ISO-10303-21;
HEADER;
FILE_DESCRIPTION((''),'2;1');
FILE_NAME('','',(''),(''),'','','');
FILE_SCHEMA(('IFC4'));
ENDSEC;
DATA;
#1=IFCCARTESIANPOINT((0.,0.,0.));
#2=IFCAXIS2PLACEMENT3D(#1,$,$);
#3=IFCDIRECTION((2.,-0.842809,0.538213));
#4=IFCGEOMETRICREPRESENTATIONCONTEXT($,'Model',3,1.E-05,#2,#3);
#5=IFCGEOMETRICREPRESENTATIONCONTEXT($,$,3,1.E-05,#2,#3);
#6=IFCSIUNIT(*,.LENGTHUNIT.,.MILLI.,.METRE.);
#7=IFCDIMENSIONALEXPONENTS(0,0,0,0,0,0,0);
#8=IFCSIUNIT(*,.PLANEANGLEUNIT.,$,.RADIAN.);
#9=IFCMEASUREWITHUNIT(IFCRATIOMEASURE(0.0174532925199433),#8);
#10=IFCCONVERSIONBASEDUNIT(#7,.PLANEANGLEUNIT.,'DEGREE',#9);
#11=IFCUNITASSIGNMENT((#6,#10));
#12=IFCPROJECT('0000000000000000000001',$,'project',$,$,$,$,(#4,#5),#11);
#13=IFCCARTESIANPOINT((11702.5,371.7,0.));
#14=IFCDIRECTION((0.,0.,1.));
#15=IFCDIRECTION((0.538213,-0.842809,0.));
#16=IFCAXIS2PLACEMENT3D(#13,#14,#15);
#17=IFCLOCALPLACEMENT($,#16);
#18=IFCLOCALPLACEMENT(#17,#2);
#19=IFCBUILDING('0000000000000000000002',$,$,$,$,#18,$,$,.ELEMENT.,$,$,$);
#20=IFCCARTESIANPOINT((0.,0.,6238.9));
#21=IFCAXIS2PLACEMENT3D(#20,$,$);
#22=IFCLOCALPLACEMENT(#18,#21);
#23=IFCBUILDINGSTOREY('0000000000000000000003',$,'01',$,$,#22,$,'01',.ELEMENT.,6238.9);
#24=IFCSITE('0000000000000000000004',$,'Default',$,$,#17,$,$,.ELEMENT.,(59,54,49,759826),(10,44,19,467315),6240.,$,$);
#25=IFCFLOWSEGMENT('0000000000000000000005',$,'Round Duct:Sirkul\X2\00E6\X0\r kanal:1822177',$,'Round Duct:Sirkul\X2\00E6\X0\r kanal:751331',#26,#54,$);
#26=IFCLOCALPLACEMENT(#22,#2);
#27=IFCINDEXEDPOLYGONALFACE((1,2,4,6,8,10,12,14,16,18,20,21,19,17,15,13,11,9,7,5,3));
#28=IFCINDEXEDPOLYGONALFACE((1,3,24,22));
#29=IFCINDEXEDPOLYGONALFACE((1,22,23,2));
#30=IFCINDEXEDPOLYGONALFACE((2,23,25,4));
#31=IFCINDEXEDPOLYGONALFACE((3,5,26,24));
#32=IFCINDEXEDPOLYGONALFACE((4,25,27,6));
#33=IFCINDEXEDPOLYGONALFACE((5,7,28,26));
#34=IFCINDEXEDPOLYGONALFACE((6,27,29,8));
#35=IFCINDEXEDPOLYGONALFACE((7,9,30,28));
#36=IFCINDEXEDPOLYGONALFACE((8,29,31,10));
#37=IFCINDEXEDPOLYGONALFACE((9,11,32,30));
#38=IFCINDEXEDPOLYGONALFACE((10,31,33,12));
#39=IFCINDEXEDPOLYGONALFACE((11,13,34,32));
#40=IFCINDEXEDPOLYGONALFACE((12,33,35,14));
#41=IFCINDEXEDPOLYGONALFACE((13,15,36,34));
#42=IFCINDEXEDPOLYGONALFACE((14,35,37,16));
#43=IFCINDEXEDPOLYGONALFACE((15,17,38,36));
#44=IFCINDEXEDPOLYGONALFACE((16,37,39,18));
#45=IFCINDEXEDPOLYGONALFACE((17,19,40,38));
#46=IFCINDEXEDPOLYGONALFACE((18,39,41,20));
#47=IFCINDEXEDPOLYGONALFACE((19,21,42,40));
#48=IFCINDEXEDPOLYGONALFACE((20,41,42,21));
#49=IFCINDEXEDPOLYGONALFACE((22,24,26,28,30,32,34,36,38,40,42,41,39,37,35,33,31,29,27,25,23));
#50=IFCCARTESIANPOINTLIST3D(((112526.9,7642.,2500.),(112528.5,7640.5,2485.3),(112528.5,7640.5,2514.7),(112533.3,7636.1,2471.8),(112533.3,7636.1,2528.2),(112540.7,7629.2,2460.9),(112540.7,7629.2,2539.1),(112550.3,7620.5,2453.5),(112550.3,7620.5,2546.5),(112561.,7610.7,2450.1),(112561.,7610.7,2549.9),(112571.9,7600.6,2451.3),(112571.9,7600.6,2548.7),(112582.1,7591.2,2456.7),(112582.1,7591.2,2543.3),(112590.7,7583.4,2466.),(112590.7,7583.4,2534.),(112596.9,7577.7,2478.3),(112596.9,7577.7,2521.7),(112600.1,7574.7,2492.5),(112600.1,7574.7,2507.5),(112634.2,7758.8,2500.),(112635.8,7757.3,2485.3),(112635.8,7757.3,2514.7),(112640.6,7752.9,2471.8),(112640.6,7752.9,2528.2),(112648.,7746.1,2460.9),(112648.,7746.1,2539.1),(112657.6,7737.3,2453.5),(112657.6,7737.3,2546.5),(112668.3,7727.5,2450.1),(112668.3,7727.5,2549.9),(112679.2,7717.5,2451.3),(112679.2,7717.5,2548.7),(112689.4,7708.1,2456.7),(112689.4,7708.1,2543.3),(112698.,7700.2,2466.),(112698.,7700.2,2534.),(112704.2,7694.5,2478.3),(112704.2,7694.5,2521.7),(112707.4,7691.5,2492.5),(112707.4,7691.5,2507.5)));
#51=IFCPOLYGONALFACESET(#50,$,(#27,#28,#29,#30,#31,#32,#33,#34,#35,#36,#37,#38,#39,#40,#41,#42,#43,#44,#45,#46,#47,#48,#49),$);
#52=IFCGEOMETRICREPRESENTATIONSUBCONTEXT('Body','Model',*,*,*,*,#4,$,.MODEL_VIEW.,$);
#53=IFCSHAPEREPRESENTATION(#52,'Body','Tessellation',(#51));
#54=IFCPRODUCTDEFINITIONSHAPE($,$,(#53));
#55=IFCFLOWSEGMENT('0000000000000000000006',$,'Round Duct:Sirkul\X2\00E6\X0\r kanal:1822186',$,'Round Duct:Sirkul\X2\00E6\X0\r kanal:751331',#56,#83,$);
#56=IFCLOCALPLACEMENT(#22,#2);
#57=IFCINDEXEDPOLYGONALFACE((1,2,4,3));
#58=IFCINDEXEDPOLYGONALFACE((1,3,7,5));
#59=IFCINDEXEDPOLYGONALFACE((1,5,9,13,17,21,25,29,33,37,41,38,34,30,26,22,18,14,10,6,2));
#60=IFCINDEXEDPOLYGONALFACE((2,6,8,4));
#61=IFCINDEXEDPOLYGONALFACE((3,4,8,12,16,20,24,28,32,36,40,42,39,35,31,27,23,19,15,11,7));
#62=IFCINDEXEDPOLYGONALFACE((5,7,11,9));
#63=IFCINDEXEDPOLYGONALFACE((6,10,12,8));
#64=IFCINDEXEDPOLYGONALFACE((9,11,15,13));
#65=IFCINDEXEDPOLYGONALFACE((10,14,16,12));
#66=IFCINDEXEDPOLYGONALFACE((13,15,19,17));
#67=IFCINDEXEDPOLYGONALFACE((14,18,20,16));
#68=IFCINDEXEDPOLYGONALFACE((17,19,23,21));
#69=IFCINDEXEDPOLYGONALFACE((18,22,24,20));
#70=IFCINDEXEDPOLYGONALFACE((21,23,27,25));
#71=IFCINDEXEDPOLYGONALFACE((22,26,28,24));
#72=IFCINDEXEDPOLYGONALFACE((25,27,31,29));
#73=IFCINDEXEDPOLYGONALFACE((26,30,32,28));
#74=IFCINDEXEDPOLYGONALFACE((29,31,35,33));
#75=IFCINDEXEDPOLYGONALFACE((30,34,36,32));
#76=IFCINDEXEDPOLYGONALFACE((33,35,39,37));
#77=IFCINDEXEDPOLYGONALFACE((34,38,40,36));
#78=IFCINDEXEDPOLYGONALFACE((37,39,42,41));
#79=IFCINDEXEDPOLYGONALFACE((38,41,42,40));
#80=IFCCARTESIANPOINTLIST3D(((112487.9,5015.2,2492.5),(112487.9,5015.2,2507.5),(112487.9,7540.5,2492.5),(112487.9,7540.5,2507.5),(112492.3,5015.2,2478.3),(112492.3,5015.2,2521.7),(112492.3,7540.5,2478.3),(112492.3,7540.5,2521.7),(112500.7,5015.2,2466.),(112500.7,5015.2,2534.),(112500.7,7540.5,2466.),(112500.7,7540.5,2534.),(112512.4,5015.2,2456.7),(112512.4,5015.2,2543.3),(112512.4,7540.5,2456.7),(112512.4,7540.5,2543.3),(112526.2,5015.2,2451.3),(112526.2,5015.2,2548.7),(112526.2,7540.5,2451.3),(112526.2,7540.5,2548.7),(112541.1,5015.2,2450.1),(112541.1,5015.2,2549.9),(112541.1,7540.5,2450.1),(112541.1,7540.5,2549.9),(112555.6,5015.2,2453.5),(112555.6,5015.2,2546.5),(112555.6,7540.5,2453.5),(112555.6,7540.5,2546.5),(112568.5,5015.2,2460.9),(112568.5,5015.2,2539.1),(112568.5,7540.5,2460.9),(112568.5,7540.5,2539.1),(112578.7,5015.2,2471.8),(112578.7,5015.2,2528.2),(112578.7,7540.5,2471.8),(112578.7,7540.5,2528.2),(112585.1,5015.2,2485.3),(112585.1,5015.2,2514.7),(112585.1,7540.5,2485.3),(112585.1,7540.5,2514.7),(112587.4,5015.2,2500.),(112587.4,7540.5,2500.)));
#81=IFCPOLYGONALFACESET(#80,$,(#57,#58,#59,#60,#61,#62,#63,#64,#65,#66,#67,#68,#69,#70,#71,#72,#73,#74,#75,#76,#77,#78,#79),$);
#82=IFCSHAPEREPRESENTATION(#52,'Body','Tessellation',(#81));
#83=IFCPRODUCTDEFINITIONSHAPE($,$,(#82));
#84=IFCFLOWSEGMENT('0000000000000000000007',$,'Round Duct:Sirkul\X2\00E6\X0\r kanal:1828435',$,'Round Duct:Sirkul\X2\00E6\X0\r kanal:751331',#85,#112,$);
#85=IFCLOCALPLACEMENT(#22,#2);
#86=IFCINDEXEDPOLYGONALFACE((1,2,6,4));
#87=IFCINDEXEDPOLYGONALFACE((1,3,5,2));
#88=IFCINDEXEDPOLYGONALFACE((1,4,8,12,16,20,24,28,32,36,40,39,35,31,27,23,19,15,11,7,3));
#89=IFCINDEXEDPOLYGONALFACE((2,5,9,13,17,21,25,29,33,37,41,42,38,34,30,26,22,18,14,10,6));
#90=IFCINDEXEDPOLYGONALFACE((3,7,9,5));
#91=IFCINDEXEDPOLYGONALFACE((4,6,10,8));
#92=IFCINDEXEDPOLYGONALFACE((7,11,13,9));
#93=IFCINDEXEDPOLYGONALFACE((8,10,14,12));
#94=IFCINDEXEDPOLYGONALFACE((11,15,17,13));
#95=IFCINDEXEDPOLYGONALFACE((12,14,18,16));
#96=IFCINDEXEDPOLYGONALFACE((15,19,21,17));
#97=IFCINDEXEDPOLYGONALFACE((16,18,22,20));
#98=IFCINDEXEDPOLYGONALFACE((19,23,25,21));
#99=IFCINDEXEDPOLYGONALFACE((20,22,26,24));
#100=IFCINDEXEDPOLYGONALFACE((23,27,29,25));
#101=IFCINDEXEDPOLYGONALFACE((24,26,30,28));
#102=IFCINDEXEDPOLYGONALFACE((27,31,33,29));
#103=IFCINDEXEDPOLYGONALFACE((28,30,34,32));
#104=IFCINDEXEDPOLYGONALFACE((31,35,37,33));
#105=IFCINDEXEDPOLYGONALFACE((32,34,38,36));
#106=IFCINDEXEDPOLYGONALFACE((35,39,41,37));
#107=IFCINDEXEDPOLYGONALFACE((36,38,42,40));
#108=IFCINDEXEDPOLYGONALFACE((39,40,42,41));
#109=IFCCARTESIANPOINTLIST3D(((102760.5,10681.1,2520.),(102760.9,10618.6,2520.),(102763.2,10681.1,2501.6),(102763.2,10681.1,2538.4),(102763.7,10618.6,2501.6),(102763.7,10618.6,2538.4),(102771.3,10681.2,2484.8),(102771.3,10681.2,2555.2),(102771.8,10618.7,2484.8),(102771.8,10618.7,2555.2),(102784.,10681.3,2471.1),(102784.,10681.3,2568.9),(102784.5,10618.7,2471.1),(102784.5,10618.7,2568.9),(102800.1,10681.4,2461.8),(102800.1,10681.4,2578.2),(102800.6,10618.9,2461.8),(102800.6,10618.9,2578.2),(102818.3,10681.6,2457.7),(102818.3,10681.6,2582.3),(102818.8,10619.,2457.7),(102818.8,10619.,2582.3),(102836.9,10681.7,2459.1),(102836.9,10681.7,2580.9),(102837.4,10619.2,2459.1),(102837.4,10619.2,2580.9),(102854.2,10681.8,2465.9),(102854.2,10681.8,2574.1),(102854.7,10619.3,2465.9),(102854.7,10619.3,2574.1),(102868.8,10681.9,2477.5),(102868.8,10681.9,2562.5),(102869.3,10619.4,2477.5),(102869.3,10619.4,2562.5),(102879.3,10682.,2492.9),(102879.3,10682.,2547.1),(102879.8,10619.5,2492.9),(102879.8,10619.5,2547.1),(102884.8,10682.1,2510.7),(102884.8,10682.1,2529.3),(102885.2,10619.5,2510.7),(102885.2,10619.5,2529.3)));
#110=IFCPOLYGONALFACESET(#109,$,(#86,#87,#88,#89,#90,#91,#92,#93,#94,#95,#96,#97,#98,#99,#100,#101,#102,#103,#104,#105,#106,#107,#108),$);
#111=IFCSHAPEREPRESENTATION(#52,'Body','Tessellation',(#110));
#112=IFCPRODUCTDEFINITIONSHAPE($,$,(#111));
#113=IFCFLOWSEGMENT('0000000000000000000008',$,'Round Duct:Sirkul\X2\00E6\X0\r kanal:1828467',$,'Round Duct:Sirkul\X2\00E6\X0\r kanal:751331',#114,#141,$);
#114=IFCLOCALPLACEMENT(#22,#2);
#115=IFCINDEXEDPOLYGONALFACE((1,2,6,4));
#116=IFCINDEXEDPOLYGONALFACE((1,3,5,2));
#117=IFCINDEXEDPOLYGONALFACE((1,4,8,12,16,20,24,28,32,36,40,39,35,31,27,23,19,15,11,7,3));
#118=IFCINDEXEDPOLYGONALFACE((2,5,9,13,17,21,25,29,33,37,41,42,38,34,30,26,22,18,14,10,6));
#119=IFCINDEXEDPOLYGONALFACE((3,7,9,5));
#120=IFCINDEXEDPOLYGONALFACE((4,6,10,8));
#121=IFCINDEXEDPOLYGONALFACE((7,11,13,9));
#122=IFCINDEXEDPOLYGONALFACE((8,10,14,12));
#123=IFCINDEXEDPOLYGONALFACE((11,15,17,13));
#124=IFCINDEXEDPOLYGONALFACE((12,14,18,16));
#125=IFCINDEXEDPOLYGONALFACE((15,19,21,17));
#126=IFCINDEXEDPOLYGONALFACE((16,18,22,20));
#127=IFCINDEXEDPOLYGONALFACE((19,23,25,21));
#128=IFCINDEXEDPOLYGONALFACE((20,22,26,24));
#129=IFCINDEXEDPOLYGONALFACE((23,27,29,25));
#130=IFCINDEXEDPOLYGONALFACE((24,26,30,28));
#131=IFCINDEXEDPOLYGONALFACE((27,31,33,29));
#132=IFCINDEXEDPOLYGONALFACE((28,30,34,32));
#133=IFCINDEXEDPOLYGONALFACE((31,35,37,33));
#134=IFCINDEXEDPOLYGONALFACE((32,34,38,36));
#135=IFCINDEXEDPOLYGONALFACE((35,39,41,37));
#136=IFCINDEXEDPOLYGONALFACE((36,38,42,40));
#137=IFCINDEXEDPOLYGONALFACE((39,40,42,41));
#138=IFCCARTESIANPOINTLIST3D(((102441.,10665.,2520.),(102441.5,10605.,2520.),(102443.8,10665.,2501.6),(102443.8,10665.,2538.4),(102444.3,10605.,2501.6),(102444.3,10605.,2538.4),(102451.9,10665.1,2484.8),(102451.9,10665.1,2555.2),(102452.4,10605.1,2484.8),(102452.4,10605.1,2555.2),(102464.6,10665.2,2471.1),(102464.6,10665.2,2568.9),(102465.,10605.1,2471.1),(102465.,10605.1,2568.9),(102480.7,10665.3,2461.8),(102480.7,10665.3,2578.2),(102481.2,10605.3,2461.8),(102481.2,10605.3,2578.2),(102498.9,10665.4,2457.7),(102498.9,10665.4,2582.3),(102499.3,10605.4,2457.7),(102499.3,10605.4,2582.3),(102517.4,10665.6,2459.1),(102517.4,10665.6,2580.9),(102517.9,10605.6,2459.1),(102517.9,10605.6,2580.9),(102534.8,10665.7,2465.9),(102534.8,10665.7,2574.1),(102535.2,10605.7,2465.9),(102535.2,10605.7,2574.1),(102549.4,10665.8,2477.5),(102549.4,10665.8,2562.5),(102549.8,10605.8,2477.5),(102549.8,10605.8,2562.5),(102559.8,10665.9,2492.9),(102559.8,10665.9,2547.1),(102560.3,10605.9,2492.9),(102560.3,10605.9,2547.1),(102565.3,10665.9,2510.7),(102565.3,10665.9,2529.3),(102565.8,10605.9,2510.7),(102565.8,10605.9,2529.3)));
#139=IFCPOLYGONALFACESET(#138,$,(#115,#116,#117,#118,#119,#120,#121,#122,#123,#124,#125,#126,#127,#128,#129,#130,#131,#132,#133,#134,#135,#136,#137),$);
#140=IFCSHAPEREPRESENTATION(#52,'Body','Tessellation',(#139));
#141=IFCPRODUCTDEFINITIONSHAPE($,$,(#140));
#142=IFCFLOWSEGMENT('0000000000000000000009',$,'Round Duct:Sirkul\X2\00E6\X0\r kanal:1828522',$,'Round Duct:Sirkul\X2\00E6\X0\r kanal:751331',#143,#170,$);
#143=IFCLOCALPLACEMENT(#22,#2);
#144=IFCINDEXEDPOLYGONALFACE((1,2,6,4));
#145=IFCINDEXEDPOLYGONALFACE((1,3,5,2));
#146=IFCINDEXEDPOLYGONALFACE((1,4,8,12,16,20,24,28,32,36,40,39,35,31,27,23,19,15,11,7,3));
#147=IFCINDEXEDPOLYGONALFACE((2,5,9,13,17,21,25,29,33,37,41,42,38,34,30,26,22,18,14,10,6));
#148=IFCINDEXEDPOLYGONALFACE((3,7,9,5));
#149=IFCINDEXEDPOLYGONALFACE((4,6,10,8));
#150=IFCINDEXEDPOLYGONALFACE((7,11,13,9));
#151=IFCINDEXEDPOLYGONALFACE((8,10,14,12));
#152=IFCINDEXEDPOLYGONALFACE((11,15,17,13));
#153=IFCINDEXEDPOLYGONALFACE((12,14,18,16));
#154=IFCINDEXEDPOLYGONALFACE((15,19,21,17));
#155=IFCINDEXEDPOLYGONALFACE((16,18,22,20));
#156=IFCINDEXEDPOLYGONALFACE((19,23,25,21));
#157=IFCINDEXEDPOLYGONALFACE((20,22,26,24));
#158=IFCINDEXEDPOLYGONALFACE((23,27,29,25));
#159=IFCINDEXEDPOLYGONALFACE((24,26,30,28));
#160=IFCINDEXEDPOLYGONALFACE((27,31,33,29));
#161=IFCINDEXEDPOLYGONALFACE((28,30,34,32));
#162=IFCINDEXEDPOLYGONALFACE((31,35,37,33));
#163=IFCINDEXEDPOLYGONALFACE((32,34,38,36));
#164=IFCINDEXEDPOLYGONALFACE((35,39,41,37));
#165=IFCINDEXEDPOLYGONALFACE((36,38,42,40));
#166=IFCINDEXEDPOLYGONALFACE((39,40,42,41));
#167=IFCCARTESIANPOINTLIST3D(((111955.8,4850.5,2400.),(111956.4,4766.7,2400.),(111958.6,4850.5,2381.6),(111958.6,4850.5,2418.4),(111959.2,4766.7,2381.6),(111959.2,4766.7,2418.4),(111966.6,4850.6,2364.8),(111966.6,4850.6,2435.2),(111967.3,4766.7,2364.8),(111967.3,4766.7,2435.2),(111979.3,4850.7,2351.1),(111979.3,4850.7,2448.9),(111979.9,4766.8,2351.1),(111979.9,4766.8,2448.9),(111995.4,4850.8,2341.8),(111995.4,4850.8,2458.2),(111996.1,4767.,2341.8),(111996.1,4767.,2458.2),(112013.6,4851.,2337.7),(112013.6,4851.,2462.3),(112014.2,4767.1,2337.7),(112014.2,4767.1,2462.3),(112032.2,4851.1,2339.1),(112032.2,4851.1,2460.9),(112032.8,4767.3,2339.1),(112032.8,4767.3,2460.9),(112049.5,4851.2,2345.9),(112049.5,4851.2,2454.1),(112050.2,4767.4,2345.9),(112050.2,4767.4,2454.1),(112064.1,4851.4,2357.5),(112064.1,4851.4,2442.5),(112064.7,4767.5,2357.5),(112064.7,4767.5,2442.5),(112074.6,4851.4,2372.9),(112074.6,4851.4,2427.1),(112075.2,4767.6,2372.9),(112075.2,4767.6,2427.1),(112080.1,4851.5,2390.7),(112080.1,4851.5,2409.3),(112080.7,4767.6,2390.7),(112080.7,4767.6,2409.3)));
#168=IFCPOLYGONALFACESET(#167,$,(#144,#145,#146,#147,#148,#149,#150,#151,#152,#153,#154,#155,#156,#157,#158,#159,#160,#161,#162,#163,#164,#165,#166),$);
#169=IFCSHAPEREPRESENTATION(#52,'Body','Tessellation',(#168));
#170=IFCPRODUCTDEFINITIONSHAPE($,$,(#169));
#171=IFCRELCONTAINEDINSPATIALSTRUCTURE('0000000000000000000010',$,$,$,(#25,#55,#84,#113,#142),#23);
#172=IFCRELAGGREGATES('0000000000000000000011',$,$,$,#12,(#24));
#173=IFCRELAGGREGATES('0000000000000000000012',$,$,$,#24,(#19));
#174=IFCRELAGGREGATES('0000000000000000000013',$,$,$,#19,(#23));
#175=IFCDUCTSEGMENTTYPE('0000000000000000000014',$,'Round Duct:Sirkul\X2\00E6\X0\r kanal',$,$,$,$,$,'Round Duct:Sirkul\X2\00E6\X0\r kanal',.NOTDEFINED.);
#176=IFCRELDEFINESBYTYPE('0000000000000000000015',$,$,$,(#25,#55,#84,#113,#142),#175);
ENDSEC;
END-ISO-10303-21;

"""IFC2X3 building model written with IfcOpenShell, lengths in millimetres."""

from ifc_helpers import new_model, entity, si_unit, converted_unit, direction, frame, frame_2d, origin, origin_2d_with_axis, place, context, subcontext, project, spatial, circle, extrude, type_object, element, save


model = new_model("IFC2X3")

# Units and contexts
model_context = context("Model", 3, precision=1e-05, world=origin(), true_north=direction((2.0, -0.842809, 0.538213)))
context_of_model = context(None, 3, precision=1e-05, world=origin(), true_north=direction((2.0, -0.842809, 0.538213)))
body_context = subcontext(model_context, "Body", "Model", "MODEL_VIEW")
ifc_project = project(units=[si_unit("LENGTHUNIT", "METRE", prefix="MILLI"), converted_unit("PLANEANGLEUNIT", "DEGREE", entity("IfcRatioMeasure", 0.0174532925199433), si_unit("PLANEANGLEUNIT", "RADIAN"), dimensions=[0, 0, 0, 0, 0, 0, 0])], contexts=[model_context, context_of_model])

# Site, building, storey
site_placement = place(None, frame((11702.5, 371.7, 0.0), z_axis=(0.0, 0.0, 1.0), x_axis=(0.538213, -0.842809, 0.0)))
site = spatial("IfcSite", under=ifc_project, at=site_placement, Name="Default", CompositionType="ELEMENT", RefLatitude=(59, 54, 49, 759826), RefLongitude=(10, 44, 19, 467315), RefElevation=6240.0)
building_placement = place(site_placement, origin())
building = spatial("IfcBuilding", under=site, at=building_placement, CompositionType="ELEMENT")
storey_placement = place(building_placement, frame((0.0, 0.0, 6238.9)))
storey = spatial("IfcBuildingStorey", under=building, at=storey_placement, Name="01", LongName="01", CompositionType="ELEMENT", Elevation=6238.9)

# Flow segments
duct_segment_type = type_object("IfcDuctSegmentType", Name="Round Duct:Sirkulær kanal", ElementType="Round Duct:Sirkulær kanal", PredefinedType="NOTDEFINED")
flow_segment_1_placement = place(storey_placement, origin())
element("IfcFlowSegment", 1, at=flow_segment_1_placement, inside=storey, type_object=duct_segment_type, Name="Round Duct:Sirkulær kanal:1822177", ObjectType="Round Duct:Sirkulær kanal:751331", context=body_context, shape_type="SweptSolid", body=[
    extrude(circle(Radius=50.0, at=frame_2d((0.0, 0.0), x_axis=(1.0, 0.0))), frame((112563.7, 7608.1, 2500.0), z_axis=(0.676389, 0.736545, 0.0), x_axis=(-0.736545, 0.676389, 0.0)), (0.0, 0.0, 1.0), 158.6),
])
flow_segment_2_placement = place(storey_placement, origin())
element("IfcFlowSegment", 2, at=flow_segment_2_placement, inside=storey, type_object=duct_segment_type, Name="Round Duct:Sirkulær kanal:1822186", ObjectType="Round Duct:Sirkulær kanal:751331", context=body_context, shape_type="SweptSolid", body=[
    extrude(circle(Radius=50.0, at=origin_2d_with_axis()), frame((112537.4, 5015.2, 2500.0), z_axis=(0.0, 1.0, 0.0), x_axis=(1.0, 0.0, 0.0)), (0.0, 0.0, 1.0), 2525.3),
])
flow_segment_3_placement = place(storey_placement, origin())
element("IfcFlowSegment", 3, at=flow_segment_3_placement, inside=storey, type_object=duct_segment_type, Name="Round Duct:Sirkulær kanal:1828435", ObjectType="Round Duct:Sirkulær kanal:751331", context=body_context, shape_type="SweptSolid", body=[
    extrude(circle(Radius=62.5, at=origin_2d_with_axis()), frame((102823.4, 10619.0, 2520.0), z_axis=(-0.007643, 0.999971, 0.0), x_axis=(-0.999971, -0.007643, 0.0)), (0.0, 0.0, 1.0), 62.5),
])
flow_segment_4_placement = place(storey_placement, origin())
element("IfcFlowSegment", 4, at=flow_segment_4_placement, inside=storey, type_object=duct_segment_type, Name="Round Duct:Sirkulær kanal:1828467", ObjectType="Round Duct:Sirkulær kanal:751331", context=body_context, shape_type="SweptSolid", body=[
    extrude(circle(Radius=62.5, at=frame_2d((0.0, 0.0), x_axis=(1.0, 0.0))), frame((102503.5, 10665.5, 2520.0), z_axis=(0.007643, -0.999971, 0.0), x_axis=(-0.999971, -0.007643, 0.0)), (0.0, 0.0, 1.0), 60.0),
])
flow_segment_5_placement = place(storey_placement, origin())
element("IfcFlowSegment", 5, at=flow_segment_5_placement, inside=storey, type_object=duct_segment_type, Name="Round Duct:Sirkulær kanal:1828522", ObjectType="Round Duct:Sirkulær kanal:751331", context=body_context, shape_type="SweptSolid", body=[
    extrude(circle(Radius=62.5, at=origin_2d_with_axis()), frame((112018.9, 4767.1, 2400.0), z_axis=(-0.007643, 0.999971, 0.0), x_axis=(-0.999971, -0.007643, 0.0)), (0.0, 0.0, 1.0), 83.9),
])

save(model, "model.ifc")
